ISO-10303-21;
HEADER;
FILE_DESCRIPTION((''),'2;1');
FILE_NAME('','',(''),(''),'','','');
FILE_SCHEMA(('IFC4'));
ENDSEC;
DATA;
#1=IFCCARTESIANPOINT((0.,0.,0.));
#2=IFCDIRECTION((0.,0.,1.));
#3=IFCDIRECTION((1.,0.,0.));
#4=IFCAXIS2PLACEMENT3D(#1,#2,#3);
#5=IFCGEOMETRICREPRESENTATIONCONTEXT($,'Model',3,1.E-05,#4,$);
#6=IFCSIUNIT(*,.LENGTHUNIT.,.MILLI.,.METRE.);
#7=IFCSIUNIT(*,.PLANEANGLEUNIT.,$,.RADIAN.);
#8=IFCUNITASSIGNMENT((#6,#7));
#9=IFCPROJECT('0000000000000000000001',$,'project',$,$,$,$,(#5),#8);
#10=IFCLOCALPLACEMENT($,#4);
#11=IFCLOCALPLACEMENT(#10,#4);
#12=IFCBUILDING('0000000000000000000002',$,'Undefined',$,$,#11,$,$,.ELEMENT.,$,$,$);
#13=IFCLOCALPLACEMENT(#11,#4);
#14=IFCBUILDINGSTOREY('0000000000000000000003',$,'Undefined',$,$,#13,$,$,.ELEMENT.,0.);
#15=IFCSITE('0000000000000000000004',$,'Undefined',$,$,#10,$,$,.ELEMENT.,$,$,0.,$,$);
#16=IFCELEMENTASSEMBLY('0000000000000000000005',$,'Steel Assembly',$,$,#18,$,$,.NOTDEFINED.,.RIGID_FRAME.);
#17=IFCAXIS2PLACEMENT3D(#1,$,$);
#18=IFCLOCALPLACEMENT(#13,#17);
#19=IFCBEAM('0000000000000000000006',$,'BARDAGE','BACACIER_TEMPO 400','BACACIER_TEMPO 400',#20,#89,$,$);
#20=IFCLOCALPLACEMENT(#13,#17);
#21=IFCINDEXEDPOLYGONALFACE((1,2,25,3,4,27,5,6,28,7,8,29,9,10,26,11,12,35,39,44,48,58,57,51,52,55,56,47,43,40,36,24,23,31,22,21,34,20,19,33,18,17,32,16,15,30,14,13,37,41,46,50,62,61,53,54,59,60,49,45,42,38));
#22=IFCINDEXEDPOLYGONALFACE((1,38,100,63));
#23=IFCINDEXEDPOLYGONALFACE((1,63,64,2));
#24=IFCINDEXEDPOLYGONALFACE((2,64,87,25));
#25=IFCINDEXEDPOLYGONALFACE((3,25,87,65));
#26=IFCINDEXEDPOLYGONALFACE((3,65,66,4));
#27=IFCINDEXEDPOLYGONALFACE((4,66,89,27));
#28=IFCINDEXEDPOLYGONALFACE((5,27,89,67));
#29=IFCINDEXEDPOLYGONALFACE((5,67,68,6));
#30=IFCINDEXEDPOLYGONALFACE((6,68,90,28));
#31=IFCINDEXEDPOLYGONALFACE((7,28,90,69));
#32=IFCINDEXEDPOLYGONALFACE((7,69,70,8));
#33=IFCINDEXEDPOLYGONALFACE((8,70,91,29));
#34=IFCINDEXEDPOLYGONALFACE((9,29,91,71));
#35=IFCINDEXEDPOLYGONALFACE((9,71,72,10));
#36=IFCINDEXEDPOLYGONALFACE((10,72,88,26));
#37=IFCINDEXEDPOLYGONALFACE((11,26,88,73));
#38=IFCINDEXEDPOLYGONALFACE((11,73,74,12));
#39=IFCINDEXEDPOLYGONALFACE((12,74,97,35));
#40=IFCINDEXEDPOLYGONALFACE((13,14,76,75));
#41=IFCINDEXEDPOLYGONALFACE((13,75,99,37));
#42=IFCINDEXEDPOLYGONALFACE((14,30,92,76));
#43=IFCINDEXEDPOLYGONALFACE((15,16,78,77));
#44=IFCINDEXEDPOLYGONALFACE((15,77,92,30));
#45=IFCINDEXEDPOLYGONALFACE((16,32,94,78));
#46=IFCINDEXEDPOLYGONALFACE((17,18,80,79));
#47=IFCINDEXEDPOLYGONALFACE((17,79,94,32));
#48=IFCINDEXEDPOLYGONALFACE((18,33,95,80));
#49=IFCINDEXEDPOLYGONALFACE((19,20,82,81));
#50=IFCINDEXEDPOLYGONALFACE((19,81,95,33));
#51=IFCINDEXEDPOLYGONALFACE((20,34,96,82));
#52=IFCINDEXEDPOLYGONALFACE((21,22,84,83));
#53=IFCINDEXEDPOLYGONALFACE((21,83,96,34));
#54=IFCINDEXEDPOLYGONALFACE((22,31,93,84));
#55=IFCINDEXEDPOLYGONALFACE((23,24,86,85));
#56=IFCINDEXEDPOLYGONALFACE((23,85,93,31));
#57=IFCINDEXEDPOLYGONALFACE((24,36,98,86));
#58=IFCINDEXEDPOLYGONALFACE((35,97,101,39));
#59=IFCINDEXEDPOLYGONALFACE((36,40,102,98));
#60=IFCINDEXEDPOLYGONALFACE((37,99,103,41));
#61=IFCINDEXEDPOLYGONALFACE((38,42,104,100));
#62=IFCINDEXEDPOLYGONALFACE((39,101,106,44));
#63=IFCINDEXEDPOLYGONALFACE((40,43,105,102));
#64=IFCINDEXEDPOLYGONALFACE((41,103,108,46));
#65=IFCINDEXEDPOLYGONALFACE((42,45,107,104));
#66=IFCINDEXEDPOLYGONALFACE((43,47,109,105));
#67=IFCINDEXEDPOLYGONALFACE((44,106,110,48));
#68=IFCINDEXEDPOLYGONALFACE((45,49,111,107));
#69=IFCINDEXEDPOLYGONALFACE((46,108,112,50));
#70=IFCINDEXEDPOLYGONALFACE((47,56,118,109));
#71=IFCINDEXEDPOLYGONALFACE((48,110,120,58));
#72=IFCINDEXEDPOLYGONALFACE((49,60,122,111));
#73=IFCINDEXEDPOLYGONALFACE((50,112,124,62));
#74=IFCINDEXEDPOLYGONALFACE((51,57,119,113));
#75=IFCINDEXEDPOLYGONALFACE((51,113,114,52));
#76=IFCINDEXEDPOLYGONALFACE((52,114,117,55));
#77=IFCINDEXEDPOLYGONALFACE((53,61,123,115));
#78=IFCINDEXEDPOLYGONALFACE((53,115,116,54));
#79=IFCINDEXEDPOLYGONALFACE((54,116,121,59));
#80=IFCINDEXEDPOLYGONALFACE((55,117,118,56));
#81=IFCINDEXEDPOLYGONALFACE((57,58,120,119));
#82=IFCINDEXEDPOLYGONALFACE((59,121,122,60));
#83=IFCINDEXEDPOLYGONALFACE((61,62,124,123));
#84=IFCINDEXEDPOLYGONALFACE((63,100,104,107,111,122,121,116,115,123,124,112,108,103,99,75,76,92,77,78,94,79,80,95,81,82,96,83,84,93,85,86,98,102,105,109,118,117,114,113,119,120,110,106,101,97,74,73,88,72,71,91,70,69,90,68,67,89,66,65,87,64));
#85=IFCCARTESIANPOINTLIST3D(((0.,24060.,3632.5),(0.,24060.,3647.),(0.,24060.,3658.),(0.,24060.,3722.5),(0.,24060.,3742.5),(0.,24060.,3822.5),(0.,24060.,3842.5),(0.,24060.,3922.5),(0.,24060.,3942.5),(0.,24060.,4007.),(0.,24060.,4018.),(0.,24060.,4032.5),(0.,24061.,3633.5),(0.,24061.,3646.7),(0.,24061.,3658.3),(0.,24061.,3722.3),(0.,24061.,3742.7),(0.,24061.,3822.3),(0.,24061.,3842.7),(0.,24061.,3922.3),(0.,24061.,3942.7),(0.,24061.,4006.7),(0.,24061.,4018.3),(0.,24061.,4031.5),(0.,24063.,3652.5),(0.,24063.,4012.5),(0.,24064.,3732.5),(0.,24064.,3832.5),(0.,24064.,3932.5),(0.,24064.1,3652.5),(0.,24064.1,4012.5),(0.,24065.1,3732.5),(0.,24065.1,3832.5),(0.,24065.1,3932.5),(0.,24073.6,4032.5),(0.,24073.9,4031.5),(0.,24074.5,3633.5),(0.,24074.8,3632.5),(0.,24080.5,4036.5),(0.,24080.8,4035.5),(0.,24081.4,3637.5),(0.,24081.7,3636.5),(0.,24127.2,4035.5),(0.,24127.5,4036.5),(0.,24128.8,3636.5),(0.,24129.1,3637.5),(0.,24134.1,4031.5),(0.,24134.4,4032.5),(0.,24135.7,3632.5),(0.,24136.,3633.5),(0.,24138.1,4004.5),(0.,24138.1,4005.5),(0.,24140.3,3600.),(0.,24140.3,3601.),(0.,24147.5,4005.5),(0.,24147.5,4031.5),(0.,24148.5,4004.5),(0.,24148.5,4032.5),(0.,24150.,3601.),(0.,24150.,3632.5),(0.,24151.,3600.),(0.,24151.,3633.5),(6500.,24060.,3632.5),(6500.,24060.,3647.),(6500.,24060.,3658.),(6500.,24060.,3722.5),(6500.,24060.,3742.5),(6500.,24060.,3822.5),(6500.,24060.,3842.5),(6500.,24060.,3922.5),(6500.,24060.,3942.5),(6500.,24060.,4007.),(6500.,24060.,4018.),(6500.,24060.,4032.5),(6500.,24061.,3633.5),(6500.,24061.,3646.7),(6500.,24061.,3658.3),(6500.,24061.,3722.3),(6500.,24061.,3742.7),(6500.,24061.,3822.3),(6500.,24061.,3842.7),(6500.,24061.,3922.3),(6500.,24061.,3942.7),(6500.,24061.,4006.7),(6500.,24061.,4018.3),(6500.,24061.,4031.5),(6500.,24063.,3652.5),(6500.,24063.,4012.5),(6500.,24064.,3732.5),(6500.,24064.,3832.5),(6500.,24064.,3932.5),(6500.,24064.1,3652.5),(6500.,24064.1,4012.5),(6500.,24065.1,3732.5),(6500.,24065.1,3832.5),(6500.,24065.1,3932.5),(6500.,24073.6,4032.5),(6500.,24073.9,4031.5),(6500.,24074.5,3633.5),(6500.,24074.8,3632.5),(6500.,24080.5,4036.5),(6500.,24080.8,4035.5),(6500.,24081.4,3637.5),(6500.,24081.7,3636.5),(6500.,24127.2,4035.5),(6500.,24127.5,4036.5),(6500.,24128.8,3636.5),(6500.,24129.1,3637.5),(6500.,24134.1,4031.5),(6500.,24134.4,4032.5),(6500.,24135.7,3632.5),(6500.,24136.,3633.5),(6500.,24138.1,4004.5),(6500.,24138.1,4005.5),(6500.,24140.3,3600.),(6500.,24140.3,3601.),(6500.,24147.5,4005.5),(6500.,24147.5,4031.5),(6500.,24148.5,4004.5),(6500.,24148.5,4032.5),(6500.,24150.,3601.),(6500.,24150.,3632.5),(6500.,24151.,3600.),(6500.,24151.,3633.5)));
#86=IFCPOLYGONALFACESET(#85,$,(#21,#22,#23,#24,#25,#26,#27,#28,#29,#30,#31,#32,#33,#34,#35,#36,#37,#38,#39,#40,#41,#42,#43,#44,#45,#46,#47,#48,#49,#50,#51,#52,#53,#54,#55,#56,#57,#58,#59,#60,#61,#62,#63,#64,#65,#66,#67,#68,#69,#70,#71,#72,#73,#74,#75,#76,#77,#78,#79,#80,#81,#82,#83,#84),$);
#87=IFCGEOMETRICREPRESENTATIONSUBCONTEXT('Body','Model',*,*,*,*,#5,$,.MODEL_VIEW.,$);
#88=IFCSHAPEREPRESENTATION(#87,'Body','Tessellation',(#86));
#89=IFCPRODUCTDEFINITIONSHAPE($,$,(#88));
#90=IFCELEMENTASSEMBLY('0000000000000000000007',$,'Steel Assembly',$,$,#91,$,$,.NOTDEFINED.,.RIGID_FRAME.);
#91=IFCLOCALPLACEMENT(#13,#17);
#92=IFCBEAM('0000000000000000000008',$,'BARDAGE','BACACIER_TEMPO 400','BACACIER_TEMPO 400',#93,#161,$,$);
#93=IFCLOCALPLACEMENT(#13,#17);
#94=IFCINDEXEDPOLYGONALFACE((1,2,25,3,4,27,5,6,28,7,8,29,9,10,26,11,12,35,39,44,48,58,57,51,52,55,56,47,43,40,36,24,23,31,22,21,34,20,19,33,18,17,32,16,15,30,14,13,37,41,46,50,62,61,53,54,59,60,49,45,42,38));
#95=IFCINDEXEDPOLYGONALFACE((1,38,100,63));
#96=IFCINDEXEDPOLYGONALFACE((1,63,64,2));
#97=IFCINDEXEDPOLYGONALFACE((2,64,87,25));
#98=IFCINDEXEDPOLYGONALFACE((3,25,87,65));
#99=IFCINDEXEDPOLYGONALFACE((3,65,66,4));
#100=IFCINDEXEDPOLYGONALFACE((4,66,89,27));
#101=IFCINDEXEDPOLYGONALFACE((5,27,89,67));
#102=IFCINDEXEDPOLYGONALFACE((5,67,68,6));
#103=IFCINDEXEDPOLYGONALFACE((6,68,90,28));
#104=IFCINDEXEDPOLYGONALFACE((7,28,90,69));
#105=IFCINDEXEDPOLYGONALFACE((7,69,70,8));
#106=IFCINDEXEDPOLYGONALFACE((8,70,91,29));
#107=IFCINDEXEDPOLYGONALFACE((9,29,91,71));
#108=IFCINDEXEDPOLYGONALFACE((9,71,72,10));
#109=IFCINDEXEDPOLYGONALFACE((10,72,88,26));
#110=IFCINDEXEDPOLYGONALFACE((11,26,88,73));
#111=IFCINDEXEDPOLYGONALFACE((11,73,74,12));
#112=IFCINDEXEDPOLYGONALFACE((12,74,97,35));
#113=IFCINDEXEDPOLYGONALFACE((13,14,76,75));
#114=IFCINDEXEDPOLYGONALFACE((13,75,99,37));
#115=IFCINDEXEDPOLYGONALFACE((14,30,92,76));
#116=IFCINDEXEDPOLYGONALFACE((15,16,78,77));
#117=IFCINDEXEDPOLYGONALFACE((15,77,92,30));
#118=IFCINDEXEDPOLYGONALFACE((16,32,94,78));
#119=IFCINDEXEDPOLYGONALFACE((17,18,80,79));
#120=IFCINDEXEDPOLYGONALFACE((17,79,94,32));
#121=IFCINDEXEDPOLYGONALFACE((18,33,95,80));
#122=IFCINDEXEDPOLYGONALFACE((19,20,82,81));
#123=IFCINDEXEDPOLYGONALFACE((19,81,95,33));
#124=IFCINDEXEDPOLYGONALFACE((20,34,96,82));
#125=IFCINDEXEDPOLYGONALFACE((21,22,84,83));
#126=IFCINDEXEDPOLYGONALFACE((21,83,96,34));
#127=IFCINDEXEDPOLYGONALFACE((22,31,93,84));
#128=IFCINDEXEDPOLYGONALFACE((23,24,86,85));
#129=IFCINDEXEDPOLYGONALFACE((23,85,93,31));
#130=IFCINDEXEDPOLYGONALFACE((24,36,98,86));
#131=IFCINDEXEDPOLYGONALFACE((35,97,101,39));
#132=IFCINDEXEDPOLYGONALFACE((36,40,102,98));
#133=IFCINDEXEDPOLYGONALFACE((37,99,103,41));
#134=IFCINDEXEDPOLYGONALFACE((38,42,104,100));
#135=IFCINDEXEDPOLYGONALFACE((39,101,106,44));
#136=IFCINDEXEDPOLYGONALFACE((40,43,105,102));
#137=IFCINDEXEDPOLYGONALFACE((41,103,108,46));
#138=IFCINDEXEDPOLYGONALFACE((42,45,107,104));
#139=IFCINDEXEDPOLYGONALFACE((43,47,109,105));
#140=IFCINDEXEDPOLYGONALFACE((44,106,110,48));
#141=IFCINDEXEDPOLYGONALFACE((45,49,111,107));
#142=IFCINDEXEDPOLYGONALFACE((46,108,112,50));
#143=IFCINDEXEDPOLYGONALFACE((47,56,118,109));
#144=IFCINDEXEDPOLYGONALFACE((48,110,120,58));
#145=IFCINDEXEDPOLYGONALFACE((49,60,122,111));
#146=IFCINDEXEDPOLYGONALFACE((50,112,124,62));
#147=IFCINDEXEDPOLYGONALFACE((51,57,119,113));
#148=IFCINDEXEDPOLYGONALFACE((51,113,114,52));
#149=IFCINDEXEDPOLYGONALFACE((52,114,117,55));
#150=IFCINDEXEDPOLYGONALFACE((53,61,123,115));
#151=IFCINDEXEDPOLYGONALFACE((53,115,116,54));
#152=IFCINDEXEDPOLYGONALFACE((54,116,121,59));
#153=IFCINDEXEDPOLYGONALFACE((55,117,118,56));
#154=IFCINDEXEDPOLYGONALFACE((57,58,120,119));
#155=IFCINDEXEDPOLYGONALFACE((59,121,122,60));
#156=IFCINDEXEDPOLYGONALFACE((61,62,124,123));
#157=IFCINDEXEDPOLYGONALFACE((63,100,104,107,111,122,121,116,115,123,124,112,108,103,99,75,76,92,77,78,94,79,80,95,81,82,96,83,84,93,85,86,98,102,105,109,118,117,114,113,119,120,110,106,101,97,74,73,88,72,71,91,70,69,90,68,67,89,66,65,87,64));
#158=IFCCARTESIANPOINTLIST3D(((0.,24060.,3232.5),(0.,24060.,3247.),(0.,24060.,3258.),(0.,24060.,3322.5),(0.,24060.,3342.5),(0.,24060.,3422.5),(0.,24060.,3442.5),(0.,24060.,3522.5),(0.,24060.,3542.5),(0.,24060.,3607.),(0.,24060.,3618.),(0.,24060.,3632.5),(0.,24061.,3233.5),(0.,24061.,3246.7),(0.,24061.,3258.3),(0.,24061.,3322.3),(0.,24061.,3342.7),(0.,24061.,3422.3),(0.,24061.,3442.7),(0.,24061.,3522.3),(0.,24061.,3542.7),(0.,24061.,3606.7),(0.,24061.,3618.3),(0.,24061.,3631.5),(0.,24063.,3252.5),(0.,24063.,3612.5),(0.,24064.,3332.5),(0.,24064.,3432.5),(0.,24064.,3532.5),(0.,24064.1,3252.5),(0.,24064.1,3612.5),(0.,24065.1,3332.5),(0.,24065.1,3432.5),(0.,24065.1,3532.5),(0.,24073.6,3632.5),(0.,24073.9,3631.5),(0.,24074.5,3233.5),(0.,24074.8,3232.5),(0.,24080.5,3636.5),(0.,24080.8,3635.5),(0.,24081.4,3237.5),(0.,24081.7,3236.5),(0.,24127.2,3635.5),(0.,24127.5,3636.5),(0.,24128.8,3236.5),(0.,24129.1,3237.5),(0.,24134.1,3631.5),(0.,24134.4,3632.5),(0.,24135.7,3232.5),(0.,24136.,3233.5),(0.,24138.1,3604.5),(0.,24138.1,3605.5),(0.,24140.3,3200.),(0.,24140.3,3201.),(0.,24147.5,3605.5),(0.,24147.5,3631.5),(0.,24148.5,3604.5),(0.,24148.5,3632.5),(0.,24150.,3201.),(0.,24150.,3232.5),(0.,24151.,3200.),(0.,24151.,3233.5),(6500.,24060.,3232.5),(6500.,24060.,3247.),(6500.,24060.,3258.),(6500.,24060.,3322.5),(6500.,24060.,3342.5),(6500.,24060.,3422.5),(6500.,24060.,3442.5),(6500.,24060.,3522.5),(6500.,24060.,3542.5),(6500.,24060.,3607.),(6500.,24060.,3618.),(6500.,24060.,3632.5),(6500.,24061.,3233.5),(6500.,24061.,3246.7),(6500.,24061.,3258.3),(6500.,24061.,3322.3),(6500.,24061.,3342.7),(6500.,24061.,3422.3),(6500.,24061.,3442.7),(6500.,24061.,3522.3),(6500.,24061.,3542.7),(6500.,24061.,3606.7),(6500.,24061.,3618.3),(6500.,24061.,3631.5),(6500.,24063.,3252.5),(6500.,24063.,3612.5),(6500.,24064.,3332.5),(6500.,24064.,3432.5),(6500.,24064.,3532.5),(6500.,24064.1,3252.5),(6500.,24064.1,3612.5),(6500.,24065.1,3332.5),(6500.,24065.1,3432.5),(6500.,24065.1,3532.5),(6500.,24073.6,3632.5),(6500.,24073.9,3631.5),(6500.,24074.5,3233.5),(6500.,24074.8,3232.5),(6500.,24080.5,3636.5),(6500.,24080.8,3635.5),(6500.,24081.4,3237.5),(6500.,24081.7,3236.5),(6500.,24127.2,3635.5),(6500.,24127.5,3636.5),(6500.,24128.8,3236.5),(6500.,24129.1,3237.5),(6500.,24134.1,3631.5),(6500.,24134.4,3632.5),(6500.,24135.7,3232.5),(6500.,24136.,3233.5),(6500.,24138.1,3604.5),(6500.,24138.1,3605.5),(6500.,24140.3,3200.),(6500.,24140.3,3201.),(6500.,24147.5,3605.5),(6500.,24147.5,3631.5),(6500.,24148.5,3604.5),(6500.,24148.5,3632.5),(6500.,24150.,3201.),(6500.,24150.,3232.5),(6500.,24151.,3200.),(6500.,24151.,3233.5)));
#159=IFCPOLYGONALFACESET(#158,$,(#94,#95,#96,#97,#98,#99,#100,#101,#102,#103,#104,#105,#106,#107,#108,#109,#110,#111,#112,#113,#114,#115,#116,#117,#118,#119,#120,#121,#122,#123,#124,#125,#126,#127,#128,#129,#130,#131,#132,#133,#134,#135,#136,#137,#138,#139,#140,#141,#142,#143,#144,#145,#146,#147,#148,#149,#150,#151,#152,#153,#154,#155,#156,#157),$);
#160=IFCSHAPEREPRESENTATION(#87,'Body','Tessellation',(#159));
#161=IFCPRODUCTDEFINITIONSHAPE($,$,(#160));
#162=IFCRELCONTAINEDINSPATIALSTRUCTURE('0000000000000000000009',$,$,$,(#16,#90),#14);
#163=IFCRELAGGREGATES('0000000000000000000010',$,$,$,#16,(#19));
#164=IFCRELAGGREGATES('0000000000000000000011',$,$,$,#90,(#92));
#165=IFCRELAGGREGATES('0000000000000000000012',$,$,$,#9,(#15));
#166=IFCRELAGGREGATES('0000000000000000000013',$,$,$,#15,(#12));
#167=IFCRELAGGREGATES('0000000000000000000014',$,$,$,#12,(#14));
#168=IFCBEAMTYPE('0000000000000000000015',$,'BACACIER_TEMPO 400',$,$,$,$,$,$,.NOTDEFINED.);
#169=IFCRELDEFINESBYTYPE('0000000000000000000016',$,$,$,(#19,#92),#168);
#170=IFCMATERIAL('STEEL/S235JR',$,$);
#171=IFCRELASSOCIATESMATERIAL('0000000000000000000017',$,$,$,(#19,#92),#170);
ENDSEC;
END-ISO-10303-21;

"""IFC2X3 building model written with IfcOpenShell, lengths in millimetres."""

from ifc_helpers import new_model, si_unit, frame, origin_with_axes, place, context, subcontext, project, spatial, polyline, outline, extrude, material, type_object, element, aggregate, save


model = new_model("IFC2X3")

# Units and contexts
model_context = context("Model", 3, precision=1e-05, world=origin_with_axes())
body_context = subcontext(model_context, "Body", "Model", "MODEL_VIEW")
ifc_project = project(units=[si_unit("LENGTHUNIT", "METRE", prefix="MILLI"), si_unit("PLANEANGLEUNIT", "RADIAN")], contexts=[model_context])

# Site, building, storey
site_placement = place(None, origin_with_axes())
site = spatial("IfcSite", under=ifc_project, at=site_placement, Name="Undefined", CompositionType="ELEMENT", RefElevation=0.0)
building_placement = place(site_placement, origin_with_axes())
building = spatial("IfcBuilding", under=site, at=building_placement, Name="Undefined", CompositionType="ELEMENT")
storey_placement = place(building_placement, origin_with_axes())
storey = spatial("IfcBuildingStorey", under=building, at=storey_placement, Name="Undefined", CompositionType="ELEMENT", Elevation=0.0)

# Element assemblies, beams
ifc_material_1 = material(Name="STEEL/S235JR")
beam_type_1 = type_object("IfcBeamType", Name="BACACIER_TEMPO 400", PredefinedType="NOTDEFINED")
assembly_1_placement = place(storey_placement, origin_with_axes())
assembly_1 = element("IfcElementAssembly", 1, at=assembly_1_placement, inside=storey, Name="Steel Assembly", AssemblyPlace="NOTDEFINED", PredefinedType="RIGID_FRAME")
beam_1_placement = place(assembly_1_placement, frame((0.0, 24105.5, 3818.2), z_axis=(0.0, 1.0, 0.0), x_axis=(1.0, 0.0, 0.0)))
beam_1 = element("IfcBeam", 2, at=beam_1_placement, type_object=beam_type_1, material=ifc_material_1, Name="BARDAGE", Description="BACACIER_TEMPO 400", ObjectType="BACACIER_TEMPO 400", context=body_context, shape_type="SweptSolid", body=[
    extrude(outline(polyline([(218.2, -25.0), (214.2, -31.9), (214.2, -45.5), (199.8, -45.5), (194.2, -42.5), (188.8, -45.5), (124.2, -45.5), (114.2, -41.5), (104.2, -45.5), (24.2, -45.5), (14.2, -41.5), (4.2, -45.5), (-75.8, -45.5), (-85.8, -41.5), (-95.8, -45.5), (-160.2, -45.5), (-165.8, -42.5), (-171.2, -45.5), (-185.8, -45.5), (-185.8, -30.7), (-181.8, -23.8), (-181.8, 23.3), (-185.8, 30.2), (-185.8, 44.5), (-217.2, 44.5), (-217.2, 34.8), (-218.2, 34.8), (-218.2, 45.5), (-184.8, 45.5), (-184.8, 30.5), (-180.8, 23.6), (-180.8, -24.1), (-184.8, -31.0), (-184.8, -44.5), (-171.5, -44.5), (-165.8, -41.4), (-160.0, -44.5), (-95.9, -44.5), (-85.8, -40.4), (-75.6, -44.5), (4.1, -44.5), (14.2, -40.4), (24.4, -44.5), (104.1, -44.5), (114.2, -40.4), (124.4, -44.5), (188.5, -44.5), (194.2, -41.4), (200.0, -44.5), (213.2, -44.5), (213.2, -31.6), (217.2, -24.7), (217.2, 21.7), (213.2, 28.6), (213.2, 42.0), (187.2, 42.0), (187.2, 32.5), (186.2, 32.5), (186.2, 43.0), (214.2, 43.0), (214.2, 28.9), (218.2, 22.0), (218.2, -25.0)])), frame((6500.0, 0.0, 0.0), z_axis=(-1.0, 0.0, 0.0), x_axis=(0.0, -1.0, 0.0)), (0.0, 0.0, 1.0), 6500.0),
])
aggregate(assembly_1, [beam_1])
assembly_2_placement = place(storey_placement, origin_with_axes())
assembly_2 = element("IfcElementAssembly", 3, at=assembly_2_placement, inside=storey, Name="Steel Assembly", AssemblyPlace="NOTDEFINED", PredefinedType="RIGID_FRAME")
beam_2_placement = place(assembly_2_placement, frame((0.0, 24105.5, 3418.2), z_axis=(0.0, 1.0, 0.0), x_axis=(1.0, 0.0, 0.0)))
beam_2 = element("IfcBeam", 4, at=beam_2_placement, type_object=beam_type_1, material=ifc_material_1, Name="BARDAGE", Description="BACACIER_TEMPO 400", ObjectType="BACACIER_TEMPO 400", context=body_context, shape_type="SweptSolid", body=[
    extrude(outline(polyline([(218.2, -25.0), (214.2, -31.9), (214.2, -45.5), (199.8, -45.5), (194.2, -42.5), (188.8, -45.5), (124.2, -45.5), (114.2, -41.5), (104.2, -45.5), (24.2, -45.5), (14.2, -41.5), (4.2, -45.5), (-75.8, -45.5), (-85.8, -41.5), (-95.8, -45.5), (-160.2, -45.5), (-165.8, -42.5), (-171.2, -45.5), (-185.8, -45.5), (-185.8, -30.7), (-181.8, -23.8), (-181.8, 23.3), (-185.8, 30.2), (-185.8, 44.5), (-217.2, 44.5), (-217.2, 34.8), (-218.2, 34.8), (-218.2, 45.5), (-184.8, 45.5), (-184.8, 30.5), (-180.8, 23.6), (-180.8, -24.1), (-184.8, -31.0), (-184.8, -44.5), (-171.5, -44.5), (-165.8, -41.4), (-160.0, -44.5), (-95.9, -44.5), (-85.8, -40.4), (-75.6, -44.5), (4.1, -44.5), (14.2, -40.4), (24.4, -44.5), (104.1, -44.5), (114.2, -40.4), (124.4, -44.5), (188.5, -44.5), (194.2, -41.4), (200.0, -44.5), (213.2, -44.5), (213.2, -31.6), (217.2, -24.7), (217.2, 21.7), (213.2, 28.6), (213.2, 42.0), (187.2, 42.0), (187.2, 32.5), (186.2, 32.5), (186.2, 43.0), (214.2, 43.0), (214.2, 28.9), (218.2, 22.0), (218.2, -25.0)])), frame((6500.0, 0.0, 0.0), z_axis=(-1.0, 0.0, 0.0), x_axis=(0.0, -1.0, 0.0)), (0.0, 0.0, 1.0), 6500.0),
])
aggregate(assembly_2, [beam_2])

save(model, "model.ifc")
